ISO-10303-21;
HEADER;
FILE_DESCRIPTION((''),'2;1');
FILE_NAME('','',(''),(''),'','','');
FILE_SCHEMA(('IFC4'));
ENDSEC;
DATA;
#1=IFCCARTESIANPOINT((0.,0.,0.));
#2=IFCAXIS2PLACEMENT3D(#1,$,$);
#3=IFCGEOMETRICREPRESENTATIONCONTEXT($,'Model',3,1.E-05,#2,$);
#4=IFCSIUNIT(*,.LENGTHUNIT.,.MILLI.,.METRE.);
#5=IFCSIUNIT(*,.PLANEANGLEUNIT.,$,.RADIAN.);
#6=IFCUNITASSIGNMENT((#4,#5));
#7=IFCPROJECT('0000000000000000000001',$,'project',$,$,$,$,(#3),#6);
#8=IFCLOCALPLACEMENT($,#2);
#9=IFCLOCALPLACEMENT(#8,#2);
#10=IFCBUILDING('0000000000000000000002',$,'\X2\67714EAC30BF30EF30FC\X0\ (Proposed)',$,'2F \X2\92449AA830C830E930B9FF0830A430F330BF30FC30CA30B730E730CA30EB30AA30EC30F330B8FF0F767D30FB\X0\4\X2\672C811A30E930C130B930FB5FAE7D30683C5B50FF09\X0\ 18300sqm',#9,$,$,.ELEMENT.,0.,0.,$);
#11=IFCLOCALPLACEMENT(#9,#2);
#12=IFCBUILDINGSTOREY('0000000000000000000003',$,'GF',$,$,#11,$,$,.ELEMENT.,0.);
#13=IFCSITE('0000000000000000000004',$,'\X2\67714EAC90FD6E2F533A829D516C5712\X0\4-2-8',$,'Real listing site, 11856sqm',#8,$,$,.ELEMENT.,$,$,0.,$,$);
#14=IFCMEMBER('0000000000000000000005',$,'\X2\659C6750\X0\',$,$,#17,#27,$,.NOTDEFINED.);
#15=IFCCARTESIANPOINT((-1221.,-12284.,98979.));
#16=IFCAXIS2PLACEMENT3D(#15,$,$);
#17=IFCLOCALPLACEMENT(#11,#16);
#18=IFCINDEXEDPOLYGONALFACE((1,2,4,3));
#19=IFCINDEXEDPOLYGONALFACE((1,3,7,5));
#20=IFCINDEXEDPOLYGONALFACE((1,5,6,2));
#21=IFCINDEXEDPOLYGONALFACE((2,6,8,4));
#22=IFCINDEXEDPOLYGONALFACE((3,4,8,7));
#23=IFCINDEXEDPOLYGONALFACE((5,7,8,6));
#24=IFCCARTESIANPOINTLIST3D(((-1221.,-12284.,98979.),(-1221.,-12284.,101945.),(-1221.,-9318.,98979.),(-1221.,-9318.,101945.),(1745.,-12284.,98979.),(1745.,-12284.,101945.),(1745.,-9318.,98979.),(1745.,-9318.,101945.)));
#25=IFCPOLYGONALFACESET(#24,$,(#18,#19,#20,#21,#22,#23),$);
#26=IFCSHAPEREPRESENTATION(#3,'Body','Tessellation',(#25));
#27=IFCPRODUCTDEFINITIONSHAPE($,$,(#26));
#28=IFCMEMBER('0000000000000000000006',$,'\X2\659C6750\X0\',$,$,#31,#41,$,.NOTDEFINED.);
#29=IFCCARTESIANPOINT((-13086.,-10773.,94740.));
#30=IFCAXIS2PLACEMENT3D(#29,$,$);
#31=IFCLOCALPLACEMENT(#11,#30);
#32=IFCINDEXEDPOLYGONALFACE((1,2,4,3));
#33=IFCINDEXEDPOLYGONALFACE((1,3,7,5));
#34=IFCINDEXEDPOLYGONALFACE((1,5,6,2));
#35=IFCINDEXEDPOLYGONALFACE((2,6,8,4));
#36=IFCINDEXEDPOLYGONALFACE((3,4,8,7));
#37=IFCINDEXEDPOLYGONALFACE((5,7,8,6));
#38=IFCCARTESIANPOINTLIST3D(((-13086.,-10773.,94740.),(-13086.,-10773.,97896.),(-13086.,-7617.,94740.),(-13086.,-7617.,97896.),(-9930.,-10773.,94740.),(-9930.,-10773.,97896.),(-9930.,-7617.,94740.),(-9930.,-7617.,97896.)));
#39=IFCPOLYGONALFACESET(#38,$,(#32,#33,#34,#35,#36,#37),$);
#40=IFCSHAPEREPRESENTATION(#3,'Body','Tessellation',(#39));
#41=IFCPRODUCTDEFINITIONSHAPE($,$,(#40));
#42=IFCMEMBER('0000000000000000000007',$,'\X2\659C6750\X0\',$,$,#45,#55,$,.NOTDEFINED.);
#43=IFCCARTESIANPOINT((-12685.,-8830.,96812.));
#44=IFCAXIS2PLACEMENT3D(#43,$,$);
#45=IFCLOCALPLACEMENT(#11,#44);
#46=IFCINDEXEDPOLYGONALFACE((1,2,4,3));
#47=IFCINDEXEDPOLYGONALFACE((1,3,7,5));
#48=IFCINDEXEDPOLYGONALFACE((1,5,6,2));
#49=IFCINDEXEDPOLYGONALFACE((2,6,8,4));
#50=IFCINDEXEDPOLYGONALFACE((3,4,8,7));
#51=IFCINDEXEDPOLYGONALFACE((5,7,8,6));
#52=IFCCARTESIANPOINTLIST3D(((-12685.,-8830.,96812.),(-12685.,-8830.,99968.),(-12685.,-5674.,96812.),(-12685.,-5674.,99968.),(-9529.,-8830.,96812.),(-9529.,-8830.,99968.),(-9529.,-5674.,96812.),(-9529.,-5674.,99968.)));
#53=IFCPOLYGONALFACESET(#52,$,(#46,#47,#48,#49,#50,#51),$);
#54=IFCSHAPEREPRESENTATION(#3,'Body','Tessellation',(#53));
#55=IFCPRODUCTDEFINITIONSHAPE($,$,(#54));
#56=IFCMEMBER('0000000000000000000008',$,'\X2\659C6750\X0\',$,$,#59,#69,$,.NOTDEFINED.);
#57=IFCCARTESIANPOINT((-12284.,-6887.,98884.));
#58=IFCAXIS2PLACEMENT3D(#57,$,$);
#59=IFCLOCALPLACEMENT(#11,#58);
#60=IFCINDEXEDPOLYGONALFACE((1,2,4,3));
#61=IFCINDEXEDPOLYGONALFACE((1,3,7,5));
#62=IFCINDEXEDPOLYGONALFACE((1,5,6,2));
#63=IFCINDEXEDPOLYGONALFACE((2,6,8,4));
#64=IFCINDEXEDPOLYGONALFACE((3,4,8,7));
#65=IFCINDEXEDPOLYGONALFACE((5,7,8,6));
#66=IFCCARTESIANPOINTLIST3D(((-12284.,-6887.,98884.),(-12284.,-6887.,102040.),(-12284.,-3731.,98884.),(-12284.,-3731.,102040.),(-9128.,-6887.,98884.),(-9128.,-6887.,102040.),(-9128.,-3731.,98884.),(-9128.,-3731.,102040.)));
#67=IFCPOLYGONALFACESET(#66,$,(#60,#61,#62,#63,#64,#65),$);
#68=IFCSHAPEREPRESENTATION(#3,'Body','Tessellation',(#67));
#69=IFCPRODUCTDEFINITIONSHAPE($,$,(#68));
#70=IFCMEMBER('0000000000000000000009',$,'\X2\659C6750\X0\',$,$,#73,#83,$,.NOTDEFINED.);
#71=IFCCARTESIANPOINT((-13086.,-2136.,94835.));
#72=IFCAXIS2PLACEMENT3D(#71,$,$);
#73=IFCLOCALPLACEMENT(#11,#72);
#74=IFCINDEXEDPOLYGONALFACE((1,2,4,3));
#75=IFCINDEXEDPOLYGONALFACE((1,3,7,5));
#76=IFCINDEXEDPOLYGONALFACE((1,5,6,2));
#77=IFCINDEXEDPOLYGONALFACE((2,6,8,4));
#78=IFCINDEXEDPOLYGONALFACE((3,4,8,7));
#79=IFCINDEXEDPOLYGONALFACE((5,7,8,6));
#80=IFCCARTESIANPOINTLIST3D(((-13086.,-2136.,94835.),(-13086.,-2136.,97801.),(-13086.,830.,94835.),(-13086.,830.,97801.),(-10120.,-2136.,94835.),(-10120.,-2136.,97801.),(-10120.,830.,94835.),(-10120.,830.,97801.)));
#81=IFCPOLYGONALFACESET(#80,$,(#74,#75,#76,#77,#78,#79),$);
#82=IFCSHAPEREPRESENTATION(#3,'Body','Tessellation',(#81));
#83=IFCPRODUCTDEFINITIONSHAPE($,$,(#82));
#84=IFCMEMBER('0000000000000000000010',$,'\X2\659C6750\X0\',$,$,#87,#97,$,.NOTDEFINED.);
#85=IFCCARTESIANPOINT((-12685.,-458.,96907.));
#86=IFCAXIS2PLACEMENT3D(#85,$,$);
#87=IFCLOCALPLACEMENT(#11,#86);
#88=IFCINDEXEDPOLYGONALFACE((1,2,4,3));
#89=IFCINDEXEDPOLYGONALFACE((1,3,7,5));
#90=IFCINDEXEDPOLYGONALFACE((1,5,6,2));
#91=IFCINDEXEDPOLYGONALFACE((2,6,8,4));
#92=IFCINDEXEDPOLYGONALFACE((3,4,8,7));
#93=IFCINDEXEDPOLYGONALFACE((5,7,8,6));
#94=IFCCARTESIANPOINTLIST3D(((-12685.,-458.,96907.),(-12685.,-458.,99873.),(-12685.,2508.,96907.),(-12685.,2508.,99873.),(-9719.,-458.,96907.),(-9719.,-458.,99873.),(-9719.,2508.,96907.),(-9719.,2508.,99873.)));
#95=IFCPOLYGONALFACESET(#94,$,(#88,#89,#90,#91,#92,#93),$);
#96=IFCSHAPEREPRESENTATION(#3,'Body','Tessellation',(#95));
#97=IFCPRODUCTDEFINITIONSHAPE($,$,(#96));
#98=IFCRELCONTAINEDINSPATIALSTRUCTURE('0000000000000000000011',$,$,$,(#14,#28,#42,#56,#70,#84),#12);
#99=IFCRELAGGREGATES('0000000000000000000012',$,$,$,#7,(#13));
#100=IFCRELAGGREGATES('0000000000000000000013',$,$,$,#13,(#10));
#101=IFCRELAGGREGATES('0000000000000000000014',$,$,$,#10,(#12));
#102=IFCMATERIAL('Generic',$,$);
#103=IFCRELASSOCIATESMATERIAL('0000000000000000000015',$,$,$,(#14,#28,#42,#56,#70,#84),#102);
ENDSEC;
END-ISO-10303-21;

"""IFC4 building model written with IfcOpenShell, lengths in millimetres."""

from ifc_helpers import new_model, si_unit, frame, frame_2d, origin, place, context, project, spatial, rectangle, extrude, material, element, save


model = new_model("IFC4")

# Units and contexts
model_context = context("Model", 3, precision=1e-05, world=origin())
ifc_project = project(units=[si_unit("LENGTHUNIT", "METRE", prefix="MILLI"), si_unit("PLANEANGLEUNIT", "RADIAN")], contexts=[model_context])

# Site, building, storey
site_placement = place(None, origin())
site = spatial("IfcSite", under=ifc_project, at=site_placement, Name="東京都港区芝公園4-2-8", ObjectType="Real listing site, 11856sqm", CompositionType="ELEMENT", RefElevation=0.0)
building_placement = place(site_placement, origin())
building = spatial("IfcBuilding", under=site, at=building_placement, Name="東京タワー (Proposed)", ObjectType="2F 鉄骨トラス（インターナショナルオレンジ／白・4本脚ラチス・微細格子） 18300sqm", CompositionType="ELEMENT", ElevationOfRefHeight=0.0, ElevationOfTerrain=0.0)
storey_placement = place(building_placement, origin())
storey = spatial("IfcBuildingStorey", under=building, at=storey_placement, Name="GF", CompositionType="ELEMENT", Elevation=0.0)

# Shared definitions
ifc_material = material(Name="Generic")

# Members
member_1_placement = place(storey_placement, frame((-1221.0, -12284.0, 98979.0)))
element("IfcMember", 1, at=member_1_placement, inside=storey, material=ifc_material, Name="斜材", PredefinedType="NOTDEFINED", context=model_context, shape_type="SweptSolid", body=[
    extrude(rectangle(XDim=2966.0, YDim=2966.0, at=frame_2d((1483.0, 1483.0))), frame((-1221.0, -12284.0, 98979.0)), (0.0, 0.0, 1.0), 2966.0),
])
member_2_placement = place(storey_placement, frame((-13086.0, -10773.0, 94740.0)))
element("IfcMember", 2, at=member_2_placement, inside=storey, material=ifc_material, Name="斜材", PredefinedType="NOTDEFINED", context=model_context, shape_type="SweptSolid", body=[
    extrude(rectangle(XDim=3156.0, YDim=3156.0, at=frame_2d((1578.0, 1578.0))), frame((-13086.0, -10773.0, 94740.0)), (0.0, 0.0, 1.0), 3156.0),
])
member_3_placement = place(storey_placement, frame((-12685.0, -8830.0, 96812.0)))
element("IfcMember", 3, at=member_3_placement, inside=storey, material=ifc_material, Name="斜材", PredefinedType="NOTDEFINED", context=model_context, shape_type="SweptSolid", body=[
    extrude(rectangle(XDim=3156.0, YDim=3156.0, at=frame_2d((1578.0, 1578.0))), frame((-12685.0, -8830.0, 96812.0)), (0.0, 0.0, 1.0), 3156.0),
])
member_4_placement = place(storey_placement, frame((-12284.0, -6887.0, 98884.0)))
element("IfcMember", 4, at=member_4_placement, inside=storey, material=ifc_material, Name="斜材", PredefinedType="NOTDEFINED", context=model_context, shape_type="SweptSolid", body=[
    extrude(rectangle(XDim=3156.0, YDim=3156.0, at=frame_2d((1578.0, 1578.0))), frame((-12284.0, -6887.0, 98884.0)), (0.0, 0.0, 1.0), 3156.0),
])
member_5_placement = place(storey_placement, frame((-13086.0, -2136.0, 94835.0)))
element("IfcMember", 5, at=member_5_placement, inside=storey, material=ifc_material, Name="斜材", PredefinedType="NOTDEFINED", context=model_context, shape_type="SweptSolid", body=[
    extrude(rectangle(XDim=2966.0, YDim=2966.0, at=frame_2d((1483.0, 1483.0))), frame((-13086.0, -2136.0, 94835.0)), (0.0, 0.0, 1.0), 2966.0),
])
member_6_placement = place(storey_placement, frame((-12685.0, -458.0, 96907.0)))
element("IfcMember", 6, at=member_6_placement, inside=storey, material=ifc_material, Name="斜材", PredefinedType="NOTDEFINED", context=model_context, shape_type="SweptSolid", body=[
    extrude(rectangle(XDim=2966.0, YDim=2966.0, at=frame_2d((1483.0, 1483.0))), frame((-12685.0, -458.0, 96907.0)), (0.0, 0.0, 1.0), 2966.0),
])

save(model, "model.ifc")
